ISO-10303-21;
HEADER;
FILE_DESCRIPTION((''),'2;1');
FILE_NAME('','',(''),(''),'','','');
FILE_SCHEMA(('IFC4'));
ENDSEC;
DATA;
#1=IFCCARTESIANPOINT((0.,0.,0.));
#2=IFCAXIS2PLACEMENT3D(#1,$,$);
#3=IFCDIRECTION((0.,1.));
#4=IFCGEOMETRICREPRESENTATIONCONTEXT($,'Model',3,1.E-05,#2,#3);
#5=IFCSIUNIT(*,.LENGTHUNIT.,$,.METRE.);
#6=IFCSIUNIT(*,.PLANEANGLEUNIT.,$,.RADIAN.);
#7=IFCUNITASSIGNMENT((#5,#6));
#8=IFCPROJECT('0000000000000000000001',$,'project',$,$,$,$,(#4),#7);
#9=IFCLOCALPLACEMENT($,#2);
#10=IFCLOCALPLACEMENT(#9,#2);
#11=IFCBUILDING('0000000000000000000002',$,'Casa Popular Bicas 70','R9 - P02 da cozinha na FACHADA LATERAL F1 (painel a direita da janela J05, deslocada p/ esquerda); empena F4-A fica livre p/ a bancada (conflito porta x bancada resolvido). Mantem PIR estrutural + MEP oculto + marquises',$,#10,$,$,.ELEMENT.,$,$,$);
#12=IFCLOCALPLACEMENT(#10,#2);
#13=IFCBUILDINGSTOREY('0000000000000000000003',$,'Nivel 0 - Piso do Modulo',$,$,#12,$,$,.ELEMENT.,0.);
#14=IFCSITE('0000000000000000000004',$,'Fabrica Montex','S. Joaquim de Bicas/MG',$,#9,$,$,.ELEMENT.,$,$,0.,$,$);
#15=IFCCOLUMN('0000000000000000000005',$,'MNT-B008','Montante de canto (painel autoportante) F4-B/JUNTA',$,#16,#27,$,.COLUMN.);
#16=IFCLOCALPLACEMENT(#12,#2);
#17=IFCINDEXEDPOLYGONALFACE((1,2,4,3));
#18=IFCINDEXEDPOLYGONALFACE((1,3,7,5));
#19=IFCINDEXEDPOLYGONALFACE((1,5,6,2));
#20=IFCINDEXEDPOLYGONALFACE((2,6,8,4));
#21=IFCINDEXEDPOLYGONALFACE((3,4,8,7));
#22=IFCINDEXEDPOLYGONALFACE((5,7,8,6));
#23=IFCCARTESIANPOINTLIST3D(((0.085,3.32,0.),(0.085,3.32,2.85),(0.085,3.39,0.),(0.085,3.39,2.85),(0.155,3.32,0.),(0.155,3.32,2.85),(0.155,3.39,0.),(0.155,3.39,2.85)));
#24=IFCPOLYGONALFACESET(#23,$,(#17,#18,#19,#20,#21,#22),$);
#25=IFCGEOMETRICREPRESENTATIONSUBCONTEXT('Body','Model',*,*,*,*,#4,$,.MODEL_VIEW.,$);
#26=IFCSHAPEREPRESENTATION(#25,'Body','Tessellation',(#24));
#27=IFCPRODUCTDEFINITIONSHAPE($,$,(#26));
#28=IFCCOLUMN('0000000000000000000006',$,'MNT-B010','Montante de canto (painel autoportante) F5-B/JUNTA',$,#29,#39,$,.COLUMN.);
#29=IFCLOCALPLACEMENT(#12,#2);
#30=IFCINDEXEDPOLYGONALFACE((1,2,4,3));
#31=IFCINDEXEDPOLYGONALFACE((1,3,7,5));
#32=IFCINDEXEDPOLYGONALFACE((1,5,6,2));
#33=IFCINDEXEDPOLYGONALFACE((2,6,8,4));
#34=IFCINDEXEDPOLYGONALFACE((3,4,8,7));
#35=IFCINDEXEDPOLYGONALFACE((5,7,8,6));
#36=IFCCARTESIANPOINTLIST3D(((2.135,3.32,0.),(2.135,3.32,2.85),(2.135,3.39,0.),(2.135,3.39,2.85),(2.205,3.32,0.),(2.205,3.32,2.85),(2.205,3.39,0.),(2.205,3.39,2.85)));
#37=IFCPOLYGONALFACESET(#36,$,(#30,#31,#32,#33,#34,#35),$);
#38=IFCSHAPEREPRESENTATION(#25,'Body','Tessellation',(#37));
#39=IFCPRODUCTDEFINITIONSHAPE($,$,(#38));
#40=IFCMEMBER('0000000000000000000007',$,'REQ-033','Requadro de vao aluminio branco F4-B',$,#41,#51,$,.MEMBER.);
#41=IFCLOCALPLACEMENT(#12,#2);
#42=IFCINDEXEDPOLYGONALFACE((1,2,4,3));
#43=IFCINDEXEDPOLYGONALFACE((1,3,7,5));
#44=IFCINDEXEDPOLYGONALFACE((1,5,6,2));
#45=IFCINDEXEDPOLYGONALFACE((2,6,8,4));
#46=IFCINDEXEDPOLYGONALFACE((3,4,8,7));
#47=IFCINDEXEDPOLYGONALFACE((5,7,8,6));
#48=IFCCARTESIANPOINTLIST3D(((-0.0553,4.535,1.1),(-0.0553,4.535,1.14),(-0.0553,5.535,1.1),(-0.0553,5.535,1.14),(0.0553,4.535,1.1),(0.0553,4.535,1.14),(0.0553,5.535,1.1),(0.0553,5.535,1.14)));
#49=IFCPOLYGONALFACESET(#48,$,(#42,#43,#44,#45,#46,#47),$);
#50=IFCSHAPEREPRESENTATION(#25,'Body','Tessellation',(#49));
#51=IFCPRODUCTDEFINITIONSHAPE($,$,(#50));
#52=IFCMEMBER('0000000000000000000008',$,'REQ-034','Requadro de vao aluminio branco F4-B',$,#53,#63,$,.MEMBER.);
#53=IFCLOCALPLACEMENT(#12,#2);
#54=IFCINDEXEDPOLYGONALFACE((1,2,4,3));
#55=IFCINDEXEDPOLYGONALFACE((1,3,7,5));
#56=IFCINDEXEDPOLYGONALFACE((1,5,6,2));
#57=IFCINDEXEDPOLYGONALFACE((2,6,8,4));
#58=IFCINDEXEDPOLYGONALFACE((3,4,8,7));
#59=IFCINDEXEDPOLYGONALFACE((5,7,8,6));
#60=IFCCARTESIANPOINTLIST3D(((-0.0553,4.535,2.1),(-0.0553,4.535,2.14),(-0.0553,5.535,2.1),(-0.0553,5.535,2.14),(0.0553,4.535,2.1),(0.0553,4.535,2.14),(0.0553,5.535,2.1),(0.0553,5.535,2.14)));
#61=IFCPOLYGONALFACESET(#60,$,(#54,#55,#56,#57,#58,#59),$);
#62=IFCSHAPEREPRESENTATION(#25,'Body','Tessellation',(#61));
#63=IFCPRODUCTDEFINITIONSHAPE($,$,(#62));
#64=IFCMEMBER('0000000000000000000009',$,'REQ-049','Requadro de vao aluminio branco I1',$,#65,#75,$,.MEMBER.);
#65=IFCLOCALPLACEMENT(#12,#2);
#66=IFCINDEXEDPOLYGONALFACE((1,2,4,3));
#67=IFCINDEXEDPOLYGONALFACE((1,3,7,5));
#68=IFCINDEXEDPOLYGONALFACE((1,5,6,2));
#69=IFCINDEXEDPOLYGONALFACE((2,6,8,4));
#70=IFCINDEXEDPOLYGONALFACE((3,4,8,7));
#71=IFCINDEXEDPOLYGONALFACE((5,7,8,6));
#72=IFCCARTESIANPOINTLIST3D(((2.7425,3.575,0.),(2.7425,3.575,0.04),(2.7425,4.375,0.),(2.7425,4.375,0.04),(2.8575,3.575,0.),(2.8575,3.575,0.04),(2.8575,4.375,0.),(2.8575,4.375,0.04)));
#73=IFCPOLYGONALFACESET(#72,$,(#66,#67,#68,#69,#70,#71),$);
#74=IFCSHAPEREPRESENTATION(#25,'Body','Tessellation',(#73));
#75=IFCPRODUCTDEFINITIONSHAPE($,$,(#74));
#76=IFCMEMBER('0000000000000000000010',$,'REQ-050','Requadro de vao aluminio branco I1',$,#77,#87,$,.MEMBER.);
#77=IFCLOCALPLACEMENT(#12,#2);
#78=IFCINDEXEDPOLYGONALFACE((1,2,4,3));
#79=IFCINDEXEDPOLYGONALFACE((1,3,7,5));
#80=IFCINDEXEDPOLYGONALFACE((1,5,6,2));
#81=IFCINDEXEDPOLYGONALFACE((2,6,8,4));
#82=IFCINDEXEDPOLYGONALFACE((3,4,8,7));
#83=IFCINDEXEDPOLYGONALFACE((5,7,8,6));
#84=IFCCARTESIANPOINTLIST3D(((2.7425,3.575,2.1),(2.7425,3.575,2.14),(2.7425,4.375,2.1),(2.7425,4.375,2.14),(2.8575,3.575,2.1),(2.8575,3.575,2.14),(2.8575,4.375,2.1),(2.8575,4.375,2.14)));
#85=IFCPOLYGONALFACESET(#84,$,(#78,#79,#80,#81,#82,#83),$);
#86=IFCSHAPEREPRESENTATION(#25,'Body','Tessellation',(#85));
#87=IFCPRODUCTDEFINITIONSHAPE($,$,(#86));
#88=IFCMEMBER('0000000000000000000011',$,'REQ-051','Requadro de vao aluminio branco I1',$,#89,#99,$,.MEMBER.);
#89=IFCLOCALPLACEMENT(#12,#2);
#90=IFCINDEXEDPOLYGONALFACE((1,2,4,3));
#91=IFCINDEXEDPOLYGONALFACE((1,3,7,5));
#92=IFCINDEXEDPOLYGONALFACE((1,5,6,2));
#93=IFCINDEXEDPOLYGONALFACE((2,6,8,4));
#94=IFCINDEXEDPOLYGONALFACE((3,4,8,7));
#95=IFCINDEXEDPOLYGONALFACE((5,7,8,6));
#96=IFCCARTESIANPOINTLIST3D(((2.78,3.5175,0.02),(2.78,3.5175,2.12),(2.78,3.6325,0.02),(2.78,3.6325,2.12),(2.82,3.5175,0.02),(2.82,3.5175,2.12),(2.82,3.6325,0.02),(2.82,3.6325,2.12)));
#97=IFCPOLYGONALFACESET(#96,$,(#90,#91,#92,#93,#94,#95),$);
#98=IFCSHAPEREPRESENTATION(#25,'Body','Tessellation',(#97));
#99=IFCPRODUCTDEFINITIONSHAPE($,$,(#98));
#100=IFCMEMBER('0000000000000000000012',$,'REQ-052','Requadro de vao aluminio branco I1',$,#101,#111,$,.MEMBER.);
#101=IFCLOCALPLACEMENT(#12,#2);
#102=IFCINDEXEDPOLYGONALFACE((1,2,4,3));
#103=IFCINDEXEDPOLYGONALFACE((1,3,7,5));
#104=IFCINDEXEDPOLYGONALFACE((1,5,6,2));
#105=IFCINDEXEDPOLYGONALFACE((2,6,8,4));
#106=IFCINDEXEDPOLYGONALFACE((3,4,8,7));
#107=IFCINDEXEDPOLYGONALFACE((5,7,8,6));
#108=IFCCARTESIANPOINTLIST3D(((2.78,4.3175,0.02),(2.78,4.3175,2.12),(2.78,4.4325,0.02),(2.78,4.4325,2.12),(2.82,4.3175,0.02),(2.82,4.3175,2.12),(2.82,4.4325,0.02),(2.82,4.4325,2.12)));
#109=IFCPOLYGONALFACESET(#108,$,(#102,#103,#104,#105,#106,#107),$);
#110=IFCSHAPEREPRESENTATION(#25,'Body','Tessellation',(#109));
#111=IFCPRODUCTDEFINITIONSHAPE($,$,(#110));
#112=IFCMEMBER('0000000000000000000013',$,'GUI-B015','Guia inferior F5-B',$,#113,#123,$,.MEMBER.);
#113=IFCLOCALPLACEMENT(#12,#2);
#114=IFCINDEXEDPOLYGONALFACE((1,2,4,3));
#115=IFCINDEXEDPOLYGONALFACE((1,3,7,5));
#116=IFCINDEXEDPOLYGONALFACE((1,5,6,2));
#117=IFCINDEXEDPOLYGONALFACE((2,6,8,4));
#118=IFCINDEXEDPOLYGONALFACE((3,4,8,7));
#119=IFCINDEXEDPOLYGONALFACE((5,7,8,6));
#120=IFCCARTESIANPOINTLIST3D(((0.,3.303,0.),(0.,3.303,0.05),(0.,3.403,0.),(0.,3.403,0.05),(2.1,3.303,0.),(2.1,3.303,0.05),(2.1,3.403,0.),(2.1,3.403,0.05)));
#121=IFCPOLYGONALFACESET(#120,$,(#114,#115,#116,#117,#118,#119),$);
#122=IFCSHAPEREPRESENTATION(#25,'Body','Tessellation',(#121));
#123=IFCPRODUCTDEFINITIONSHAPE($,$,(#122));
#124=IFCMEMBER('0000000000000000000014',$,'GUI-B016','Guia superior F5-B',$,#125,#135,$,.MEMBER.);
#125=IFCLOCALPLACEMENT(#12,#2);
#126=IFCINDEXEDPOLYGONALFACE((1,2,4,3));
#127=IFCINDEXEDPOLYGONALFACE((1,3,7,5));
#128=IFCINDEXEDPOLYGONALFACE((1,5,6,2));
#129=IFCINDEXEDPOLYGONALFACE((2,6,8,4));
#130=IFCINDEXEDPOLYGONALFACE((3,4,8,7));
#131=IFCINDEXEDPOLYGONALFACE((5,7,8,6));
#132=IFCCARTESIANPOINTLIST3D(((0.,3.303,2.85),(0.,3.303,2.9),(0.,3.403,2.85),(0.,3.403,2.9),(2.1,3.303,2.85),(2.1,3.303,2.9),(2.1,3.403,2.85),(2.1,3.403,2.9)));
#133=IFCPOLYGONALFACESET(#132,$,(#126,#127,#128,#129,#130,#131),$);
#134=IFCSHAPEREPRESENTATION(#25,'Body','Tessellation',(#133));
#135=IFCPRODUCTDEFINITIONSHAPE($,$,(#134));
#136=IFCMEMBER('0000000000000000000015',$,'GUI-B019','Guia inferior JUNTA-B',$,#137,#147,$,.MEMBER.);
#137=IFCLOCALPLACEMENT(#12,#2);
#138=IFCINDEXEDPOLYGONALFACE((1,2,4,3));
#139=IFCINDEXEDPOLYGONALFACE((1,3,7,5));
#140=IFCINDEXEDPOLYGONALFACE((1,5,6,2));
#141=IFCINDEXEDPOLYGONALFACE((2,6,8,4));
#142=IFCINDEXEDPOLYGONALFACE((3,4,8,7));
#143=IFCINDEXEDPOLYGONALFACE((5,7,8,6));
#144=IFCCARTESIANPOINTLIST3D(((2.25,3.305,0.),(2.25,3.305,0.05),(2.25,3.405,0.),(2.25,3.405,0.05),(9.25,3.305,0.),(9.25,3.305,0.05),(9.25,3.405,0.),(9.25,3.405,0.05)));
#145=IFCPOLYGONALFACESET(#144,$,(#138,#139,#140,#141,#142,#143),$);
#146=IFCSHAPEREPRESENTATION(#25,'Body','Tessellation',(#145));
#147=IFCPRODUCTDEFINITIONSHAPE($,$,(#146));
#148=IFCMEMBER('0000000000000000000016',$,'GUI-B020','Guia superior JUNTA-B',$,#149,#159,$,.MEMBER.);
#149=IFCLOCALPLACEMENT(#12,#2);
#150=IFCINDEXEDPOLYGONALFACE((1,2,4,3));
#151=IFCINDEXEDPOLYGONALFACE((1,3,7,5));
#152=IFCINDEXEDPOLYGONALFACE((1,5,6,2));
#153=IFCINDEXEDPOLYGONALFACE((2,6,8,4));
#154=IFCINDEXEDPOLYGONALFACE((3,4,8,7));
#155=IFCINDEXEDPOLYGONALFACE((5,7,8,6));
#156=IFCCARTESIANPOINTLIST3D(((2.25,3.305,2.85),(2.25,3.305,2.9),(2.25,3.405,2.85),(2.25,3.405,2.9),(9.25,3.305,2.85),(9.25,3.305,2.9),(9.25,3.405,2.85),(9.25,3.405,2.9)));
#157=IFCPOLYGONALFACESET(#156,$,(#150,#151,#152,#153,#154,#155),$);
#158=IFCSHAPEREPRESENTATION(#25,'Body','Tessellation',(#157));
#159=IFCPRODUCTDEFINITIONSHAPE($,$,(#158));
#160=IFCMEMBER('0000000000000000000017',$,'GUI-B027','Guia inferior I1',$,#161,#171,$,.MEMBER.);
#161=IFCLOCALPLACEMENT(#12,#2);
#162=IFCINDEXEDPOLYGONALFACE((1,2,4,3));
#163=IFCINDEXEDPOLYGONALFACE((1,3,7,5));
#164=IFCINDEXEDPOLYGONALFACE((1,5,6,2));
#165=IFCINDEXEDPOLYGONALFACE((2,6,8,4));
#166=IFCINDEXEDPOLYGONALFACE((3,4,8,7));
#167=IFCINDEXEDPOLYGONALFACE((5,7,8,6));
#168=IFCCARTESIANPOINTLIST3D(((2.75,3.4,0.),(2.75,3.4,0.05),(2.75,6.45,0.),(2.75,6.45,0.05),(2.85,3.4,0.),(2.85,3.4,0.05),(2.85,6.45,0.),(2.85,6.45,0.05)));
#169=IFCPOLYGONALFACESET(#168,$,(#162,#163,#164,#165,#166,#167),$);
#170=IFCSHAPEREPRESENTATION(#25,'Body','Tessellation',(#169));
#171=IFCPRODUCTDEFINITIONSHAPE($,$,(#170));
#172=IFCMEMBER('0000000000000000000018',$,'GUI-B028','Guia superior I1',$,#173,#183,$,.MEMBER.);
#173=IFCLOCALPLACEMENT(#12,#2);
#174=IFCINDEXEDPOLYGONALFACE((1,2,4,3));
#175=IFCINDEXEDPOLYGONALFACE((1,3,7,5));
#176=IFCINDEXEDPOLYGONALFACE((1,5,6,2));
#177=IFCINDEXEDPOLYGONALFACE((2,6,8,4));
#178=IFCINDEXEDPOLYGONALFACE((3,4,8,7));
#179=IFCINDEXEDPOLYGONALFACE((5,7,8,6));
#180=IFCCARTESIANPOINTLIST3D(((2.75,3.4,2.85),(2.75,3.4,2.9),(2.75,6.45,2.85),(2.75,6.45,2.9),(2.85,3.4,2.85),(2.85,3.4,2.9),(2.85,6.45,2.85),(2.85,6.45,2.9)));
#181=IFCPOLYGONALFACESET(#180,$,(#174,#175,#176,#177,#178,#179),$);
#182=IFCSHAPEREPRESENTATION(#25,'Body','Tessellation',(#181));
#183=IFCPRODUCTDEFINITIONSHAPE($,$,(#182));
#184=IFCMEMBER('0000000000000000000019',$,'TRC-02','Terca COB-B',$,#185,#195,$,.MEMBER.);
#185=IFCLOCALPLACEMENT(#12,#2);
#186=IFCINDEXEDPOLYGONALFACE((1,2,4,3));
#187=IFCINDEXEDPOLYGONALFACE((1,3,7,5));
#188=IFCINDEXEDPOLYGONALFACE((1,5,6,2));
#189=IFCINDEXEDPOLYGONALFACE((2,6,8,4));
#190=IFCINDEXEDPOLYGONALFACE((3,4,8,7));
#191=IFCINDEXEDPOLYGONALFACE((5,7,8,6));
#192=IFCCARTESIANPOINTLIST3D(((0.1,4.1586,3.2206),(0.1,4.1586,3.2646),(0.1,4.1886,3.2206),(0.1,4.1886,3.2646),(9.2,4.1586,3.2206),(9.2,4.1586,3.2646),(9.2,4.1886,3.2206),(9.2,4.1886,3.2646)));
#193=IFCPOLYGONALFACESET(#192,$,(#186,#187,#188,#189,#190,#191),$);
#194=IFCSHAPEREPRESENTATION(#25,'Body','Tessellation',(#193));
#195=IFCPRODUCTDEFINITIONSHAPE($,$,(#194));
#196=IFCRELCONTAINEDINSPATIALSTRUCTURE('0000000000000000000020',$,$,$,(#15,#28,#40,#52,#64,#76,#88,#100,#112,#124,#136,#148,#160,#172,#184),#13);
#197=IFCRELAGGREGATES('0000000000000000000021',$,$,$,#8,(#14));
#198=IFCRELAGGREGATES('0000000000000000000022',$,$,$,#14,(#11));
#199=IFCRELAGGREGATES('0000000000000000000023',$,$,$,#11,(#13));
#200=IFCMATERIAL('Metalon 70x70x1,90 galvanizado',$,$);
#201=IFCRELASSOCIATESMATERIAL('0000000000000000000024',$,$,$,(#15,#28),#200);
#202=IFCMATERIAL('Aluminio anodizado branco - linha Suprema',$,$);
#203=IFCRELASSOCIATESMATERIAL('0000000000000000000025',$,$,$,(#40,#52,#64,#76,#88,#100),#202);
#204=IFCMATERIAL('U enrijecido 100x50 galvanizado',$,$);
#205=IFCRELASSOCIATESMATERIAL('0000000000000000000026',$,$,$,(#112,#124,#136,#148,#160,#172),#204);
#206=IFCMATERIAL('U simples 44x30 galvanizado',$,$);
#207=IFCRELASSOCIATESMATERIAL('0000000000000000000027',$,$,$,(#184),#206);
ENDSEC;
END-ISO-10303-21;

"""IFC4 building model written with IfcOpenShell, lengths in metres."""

from ifc_helpers import new_model, si_unit, direction, frame, origin, origin_2d, place, context, subcontext, project, spatial, rectangle, extrude, material, element, save


model = new_model("IFC4")

# Units and contexts
model_context = context("Model", 3, precision=1e-05, world=origin(), true_north=direction((0.0, 1.0)))
body_context = subcontext(model_context, "Body", "Model", "MODEL_VIEW")
ifc_project = project(units=[si_unit("LENGTHUNIT", "METRE"), si_unit("PLANEANGLEUNIT", "RADIAN")], contexts=[model_context])

# Site, building, storey
site_placement = place(None, origin())
site = spatial("IfcSite", under=ifc_project, at=site_placement, Name="Fabrica Montex", Description="S. Joaquim de Bicas/MG", CompositionType="ELEMENT", RefElevation=0.0)
building_placement = place(site_placement, origin())
building = spatial("IfcBuilding", under=site, at=building_placement, Name="Casa Popular Bicas 70", Description="R9 - P02 da cozinha na FACHADA LATERAL F1 (painel a direita da janela J05, deslocada p/ esquerda); empena F4-A fica livre p/ a bancada (conflito porta x bancada resolvido). Mantem PIR estrutural + MEP oculto + marquises", CompositionType="ELEMENT")
storey_placement = place(building_placement, origin())
storey = spatial("IfcBuildingStorey", under=building, at=storey_placement, Name="Nivel 0 - Piso do Modulo", CompositionType="ELEMENT", Elevation=0.0)

# Columns
ifc_material_1 = material(Name="Metalon 70x70x1,90 galvanizado")
for number, where, name, description in (
    (1, (0.12, 3.355, 0.0), "MNT-B008", "Montante de canto (painel autoportante) F4-B/JUNTA"),
    (2, (2.17, 3.355, 0.0), "MNT-B010", "Montante de canto (painel autoportante) F5-B/JUNTA"),
):
    element("IfcColumn", number, at=place(storey_placement, frame(where)), inside=storey, material=ifc_material_1, Name=name, Description=description, PredefinedType="COLUMN", context=body_context, shape_type="SweptSolid", body=[
        extrude(rectangle(XDim=0.07, YDim=0.07, at=origin_2d()), origin(), (0.0, 0.0, 1.0), 2.85),
    ])

# Members
ifc_material_2 = material(Name="Aluminio anodizado branco - linha Suprema")
for number, where, z_axis, x_axis, name in (
    (3, (0.0, 4.535, 1.12), (0.0, 1.0, 0.0), (0.0, 0.0, 1.0), "REQ-033"),
    (4, (0.0, 4.535, 2.12), (0.0, 1.0, 0.0), (0.0, 0.0, 1.0), "REQ-034"),
):
    element("IfcMember", number, at=place(storey_placement, frame(where, z_axis=z_axis, x_axis=x_axis)), inside=storey, material=ifc_material_2, Name=name, Description="Requadro de vao aluminio branco F4-B", PredefinedType="MEMBER", context=body_context, shape_type="SweptSolid", body=[
        extrude(rectangle(XDim=0.04, YDim=0.1105, at=origin_2d()), origin(), (0.0, 0.0, 1.0), 1.0),
    ])
for number, where, z_axis, x_axis, name in (
    (5, (2.8, 3.575, 0.02), (0.0, 1.0, 0.0), (0.0, 0.0, 1.0), "REQ-049"),
    (6, (2.8, 3.575, 2.12), (0.0, 1.0, 0.0), (0.0, 0.0, 1.0), "REQ-050"),
):
    element("IfcMember", number, at=place(storey_placement, frame(where, z_axis=z_axis, x_axis=x_axis)), inside=storey, material=ifc_material_2, Name=name, Description="Requadro de vao aluminio branco I1", PredefinedType="MEMBER", context=body_context, shape_type="SweptSolid", body=[
        extrude(rectangle(XDim=0.04, YDim=0.115, at=origin_2d()), origin(), (0.0, 0.0, 1.0), 0.8),
    ])
for number, where, z_axis, x_axis, name in (
    (7, (2.8, 3.575, 0.02), (0.0, 0.0, 1.0), (1.0, 0.0, 0.0), "REQ-051"),
    (8, (2.8, 4.375, 0.02), (0.0, 0.0, 1.0), (1.0, 0.0, 0.0), "REQ-052"),
):
    element("IfcMember", number, at=place(storey_placement, frame(where, z_axis=z_axis, x_axis=x_axis)), inside=storey, material=ifc_material_2, Name=name, Description="Requadro de vao aluminio branco I1", PredefinedType="MEMBER", context=body_context, shape_type="SweptSolid", body=[
        extrude(rectangle(XDim=0.04, YDim=0.115, at=origin_2d()), origin(), (0.0, 0.0, 1.0), 2.1),
    ])
ifc_material_3 = material(Name="U enrijecido 100x50 galvanizado")
for number, where, z_axis, x_axis, name, description in (
    (9, (0.0, 3.353, 0.025), (1.0, 0.0, 0.0), (0.0, 0.0, 1.0), "GUI-B015", "Guia inferior F5-B"),
    (10, (0.0, 3.353, 2.875), (1.0, 0.0, 0.0), (0.0, 0.0, 1.0), "GUI-B016", "Guia superior F5-B"),
):
    element("IfcMember", number, at=place(storey_placement, frame(where, z_axis=z_axis, x_axis=x_axis)), inside=storey, material=ifc_material_3, Name=name, Description=description, PredefinedType="MEMBER", context=body_context, shape_type="SweptSolid", body=[
        extrude(rectangle(XDim=0.05, YDim=0.1, at=origin_2d()), origin(), (0.0, 0.0, 1.0), 2.1),
    ])
for number, where, z_axis, x_axis, name, description in (
    (11, (2.25, 3.355, 0.025), (1.0, 0.0, 0.0), (0.0, 0.0, 1.0), "GUI-B019", "Guia inferior JUNTA-B"),
    (12, (2.25, 3.355, 2.875), (1.0, 0.0, 0.0), (0.0, 0.0, 1.0), "GUI-B020", "Guia superior JUNTA-B"),
):
    element("IfcMember", number, at=place(storey_placement, frame(where, z_axis=z_axis, x_axis=x_axis)), inside=storey, material=ifc_material_3, Name=name, Description=description, PredefinedType="MEMBER", context=body_context, shape_type="SweptSolid", body=[
        extrude(rectangle(XDim=0.05, YDim=0.1, at=origin_2d()), origin(), (0.0, 0.0, 1.0), 7.0),
    ])
for number, where, z_axis, x_axis, name, description in (
    (13, (2.8, 3.4, 0.025), (0.0, 1.0, 0.0), (0.0, 0.0, 1.0), "GUI-B027", "Guia inferior I1"),
    (14, (2.8, 3.4, 2.875), (0.0, 1.0, 0.0), (0.0, 0.0, 1.0), "GUI-B028", "Guia superior I1"),
):
    element("IfcMember", number, at=place(storey_placement, frame(where, z_axis=z_axis, x_axis=x_axis)), inside=storey, material=ifc_material_3, Name=name, Description=description, PredefinedType="MEMBER", context=body_context, shape_type="SweptSolid", body=[
        extrude(rectangle(XDim=0.05, YDim=0.1, at=origin_2d()), origin(), (0.0, 0.0, 1.0), 3.05),
    ])
ifc_material_4 = material(Name="U simples 44x30 galvanizado")
member_placement = place(storey_placement, frame((0.1, 4.1736, 3.2426), z_axis=(1.0, 0.0, 0.0), x_axis=(0.0, 0.0, 1.0)))
element("IfcMember", 15, at=member_placement, inside=storey, material=ifc_material_4, Name="TRC-02", Description="Terca COB-B", PredefinedType="MEMBER", context=body_context, shape_type="SweptSolid", body=[
    extrude(rectangle(XDim=0.044, YDim=0.03, at=origin_2d()), origin(), (0.0, 0.0, 1.0), 9.1),
])

save(model, "model.ifc")
